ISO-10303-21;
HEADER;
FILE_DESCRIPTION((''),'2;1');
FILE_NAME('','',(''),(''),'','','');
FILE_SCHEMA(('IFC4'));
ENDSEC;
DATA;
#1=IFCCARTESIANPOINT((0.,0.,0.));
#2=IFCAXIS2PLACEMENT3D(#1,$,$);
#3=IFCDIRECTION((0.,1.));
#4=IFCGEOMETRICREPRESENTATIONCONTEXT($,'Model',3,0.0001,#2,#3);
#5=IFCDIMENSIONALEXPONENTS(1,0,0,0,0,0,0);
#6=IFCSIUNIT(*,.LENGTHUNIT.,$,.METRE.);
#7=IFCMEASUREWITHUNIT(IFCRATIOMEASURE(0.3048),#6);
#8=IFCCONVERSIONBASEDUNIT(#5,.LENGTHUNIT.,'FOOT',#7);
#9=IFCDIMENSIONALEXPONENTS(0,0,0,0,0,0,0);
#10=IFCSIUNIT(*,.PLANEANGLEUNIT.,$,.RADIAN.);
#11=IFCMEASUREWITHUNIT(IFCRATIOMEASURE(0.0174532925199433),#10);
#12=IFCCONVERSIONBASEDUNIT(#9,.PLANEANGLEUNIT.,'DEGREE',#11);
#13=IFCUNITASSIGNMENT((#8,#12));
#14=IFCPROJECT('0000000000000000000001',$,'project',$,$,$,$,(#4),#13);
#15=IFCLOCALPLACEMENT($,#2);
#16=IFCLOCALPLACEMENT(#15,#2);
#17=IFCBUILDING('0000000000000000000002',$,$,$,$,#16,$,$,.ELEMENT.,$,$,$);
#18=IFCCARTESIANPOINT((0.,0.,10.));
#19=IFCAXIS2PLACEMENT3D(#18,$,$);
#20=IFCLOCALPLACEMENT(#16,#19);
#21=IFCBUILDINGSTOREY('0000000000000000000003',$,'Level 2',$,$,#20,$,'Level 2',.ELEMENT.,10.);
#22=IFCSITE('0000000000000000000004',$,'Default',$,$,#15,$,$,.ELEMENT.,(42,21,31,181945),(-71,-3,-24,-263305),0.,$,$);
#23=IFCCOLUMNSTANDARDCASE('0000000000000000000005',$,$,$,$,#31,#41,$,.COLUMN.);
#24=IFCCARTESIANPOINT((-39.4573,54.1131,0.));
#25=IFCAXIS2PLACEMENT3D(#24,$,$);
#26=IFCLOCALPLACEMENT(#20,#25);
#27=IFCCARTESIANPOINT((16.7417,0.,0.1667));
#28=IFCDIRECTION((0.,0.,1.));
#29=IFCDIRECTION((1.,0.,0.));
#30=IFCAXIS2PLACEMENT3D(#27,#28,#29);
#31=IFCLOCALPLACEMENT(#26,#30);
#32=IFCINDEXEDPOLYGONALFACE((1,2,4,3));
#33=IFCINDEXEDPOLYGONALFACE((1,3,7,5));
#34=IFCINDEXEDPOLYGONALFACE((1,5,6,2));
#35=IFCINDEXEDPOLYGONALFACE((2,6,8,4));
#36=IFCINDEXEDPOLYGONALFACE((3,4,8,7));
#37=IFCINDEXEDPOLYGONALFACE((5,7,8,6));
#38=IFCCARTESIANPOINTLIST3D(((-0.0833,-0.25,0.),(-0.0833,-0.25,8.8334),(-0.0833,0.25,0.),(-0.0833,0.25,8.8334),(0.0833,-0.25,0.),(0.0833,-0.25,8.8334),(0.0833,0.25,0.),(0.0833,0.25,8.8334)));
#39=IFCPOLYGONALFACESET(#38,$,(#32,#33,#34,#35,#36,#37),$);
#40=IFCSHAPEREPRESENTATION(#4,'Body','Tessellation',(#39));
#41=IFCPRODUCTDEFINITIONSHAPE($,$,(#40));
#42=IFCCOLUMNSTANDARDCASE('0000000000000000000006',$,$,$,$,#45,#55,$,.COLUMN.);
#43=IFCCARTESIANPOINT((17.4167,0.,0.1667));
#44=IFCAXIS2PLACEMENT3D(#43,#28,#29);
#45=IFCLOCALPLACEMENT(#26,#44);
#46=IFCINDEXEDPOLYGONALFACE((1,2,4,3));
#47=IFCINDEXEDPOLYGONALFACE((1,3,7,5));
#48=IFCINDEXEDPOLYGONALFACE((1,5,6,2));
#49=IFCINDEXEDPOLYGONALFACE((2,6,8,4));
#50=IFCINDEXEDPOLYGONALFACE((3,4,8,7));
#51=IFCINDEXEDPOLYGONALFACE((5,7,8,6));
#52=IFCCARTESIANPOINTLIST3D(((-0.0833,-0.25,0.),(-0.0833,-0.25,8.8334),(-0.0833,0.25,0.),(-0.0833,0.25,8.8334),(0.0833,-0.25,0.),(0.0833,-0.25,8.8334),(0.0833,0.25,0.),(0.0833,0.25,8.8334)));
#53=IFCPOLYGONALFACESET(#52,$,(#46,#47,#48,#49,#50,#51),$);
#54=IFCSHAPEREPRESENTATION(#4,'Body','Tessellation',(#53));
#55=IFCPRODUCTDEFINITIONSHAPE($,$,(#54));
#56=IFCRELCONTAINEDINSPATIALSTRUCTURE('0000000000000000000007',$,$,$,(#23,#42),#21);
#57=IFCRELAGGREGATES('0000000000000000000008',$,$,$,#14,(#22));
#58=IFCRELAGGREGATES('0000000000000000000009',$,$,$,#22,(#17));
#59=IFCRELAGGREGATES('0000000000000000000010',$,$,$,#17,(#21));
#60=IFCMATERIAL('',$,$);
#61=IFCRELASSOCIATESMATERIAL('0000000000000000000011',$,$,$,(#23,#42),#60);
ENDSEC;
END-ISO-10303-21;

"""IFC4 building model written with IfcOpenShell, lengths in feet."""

from ifc_helpers import new_model, entity, si_unit, converted_unit, direction, frame, origin, place, context, project, spatial, rectangle, extrude, material, element, save


model = new_model("IFC4")

# Units and contexts
model_context = context("Model", 3, precision=0.0001, world=origin(), true_north=direction((0.0, 1.0)))
ifc_project = project(units=[converted_unit("LENGTHUNIT", "FOOT", entity("IfcRatioMeasure", 0.3048), si_unit("LENGTHUNIT", "METRE"), dimensions=[1, 0, 0, 0, 0, 0, 0]), converted_unit("PLANEANGLEUNIT", "DEGREE", entity("IfcRatioMeasure", 0.0174532925199433), si_unit("PLANEANGLEUNIT", "RADIAN"), dimensions=[0, 0, 0, 0, 0, 0, 0])], contexts=[model_context])

# Site, building, storey
site_placement = place(None, origin())
site = spatial("IfcSite", under=ifc_project, at=site_placement, Name="Default", CompositionType="ELEMENT", RefLatitude=(42, 21, 31, 181945), RefLongitude=(-71, -3, -24, -263305), RefElevation=0.0)
building_placement = place(site_placement, origin())
building = spatial("IfcBuilding", under=site, at=building_placement, CompositionType="ELEMENT")
storey_placement = place(building_placement, frame((0.0, 0.0, 10.0)))
storey = spatial("IfcBuildingStorey", under=building, at=storey_placement, Name="Level 2", LongName="Level 2", CompositionType="ELEMENT", Elevation=10.0)

# Columns
ifc_material_1 = material(Name="")
placement_1 = place(storey_placement, frame((-39.4573, 54.1131, 0.0)))
for number, where, z_axis, x_axis in (
    (1, (16.7417, 0.0, 0.1667), (0.0, 0.0, 1.0), (1.0, 0.0, 0.0)),
    (2, (17.4167, 0.0, 0.1667), (0.0, 0.0, 1.0), (1.0, 0.0, 0.0)),
):
    element("IfcColumnStandardCase", number, at=place(placement_1, frame(where, z_axis=z_axis, x_axis=x_axis)), inside=storey, material=ifc_material_1, PredefinedType="COLUMN", context=model_context, shape_type="SweptSolid", body=[
        extrude(rectangle(XDim=0.1667, YDim=0.5), origin(), (0.0, 0.0, 1.0), 8.8334),
    ])

save(model, "model.ifc")
